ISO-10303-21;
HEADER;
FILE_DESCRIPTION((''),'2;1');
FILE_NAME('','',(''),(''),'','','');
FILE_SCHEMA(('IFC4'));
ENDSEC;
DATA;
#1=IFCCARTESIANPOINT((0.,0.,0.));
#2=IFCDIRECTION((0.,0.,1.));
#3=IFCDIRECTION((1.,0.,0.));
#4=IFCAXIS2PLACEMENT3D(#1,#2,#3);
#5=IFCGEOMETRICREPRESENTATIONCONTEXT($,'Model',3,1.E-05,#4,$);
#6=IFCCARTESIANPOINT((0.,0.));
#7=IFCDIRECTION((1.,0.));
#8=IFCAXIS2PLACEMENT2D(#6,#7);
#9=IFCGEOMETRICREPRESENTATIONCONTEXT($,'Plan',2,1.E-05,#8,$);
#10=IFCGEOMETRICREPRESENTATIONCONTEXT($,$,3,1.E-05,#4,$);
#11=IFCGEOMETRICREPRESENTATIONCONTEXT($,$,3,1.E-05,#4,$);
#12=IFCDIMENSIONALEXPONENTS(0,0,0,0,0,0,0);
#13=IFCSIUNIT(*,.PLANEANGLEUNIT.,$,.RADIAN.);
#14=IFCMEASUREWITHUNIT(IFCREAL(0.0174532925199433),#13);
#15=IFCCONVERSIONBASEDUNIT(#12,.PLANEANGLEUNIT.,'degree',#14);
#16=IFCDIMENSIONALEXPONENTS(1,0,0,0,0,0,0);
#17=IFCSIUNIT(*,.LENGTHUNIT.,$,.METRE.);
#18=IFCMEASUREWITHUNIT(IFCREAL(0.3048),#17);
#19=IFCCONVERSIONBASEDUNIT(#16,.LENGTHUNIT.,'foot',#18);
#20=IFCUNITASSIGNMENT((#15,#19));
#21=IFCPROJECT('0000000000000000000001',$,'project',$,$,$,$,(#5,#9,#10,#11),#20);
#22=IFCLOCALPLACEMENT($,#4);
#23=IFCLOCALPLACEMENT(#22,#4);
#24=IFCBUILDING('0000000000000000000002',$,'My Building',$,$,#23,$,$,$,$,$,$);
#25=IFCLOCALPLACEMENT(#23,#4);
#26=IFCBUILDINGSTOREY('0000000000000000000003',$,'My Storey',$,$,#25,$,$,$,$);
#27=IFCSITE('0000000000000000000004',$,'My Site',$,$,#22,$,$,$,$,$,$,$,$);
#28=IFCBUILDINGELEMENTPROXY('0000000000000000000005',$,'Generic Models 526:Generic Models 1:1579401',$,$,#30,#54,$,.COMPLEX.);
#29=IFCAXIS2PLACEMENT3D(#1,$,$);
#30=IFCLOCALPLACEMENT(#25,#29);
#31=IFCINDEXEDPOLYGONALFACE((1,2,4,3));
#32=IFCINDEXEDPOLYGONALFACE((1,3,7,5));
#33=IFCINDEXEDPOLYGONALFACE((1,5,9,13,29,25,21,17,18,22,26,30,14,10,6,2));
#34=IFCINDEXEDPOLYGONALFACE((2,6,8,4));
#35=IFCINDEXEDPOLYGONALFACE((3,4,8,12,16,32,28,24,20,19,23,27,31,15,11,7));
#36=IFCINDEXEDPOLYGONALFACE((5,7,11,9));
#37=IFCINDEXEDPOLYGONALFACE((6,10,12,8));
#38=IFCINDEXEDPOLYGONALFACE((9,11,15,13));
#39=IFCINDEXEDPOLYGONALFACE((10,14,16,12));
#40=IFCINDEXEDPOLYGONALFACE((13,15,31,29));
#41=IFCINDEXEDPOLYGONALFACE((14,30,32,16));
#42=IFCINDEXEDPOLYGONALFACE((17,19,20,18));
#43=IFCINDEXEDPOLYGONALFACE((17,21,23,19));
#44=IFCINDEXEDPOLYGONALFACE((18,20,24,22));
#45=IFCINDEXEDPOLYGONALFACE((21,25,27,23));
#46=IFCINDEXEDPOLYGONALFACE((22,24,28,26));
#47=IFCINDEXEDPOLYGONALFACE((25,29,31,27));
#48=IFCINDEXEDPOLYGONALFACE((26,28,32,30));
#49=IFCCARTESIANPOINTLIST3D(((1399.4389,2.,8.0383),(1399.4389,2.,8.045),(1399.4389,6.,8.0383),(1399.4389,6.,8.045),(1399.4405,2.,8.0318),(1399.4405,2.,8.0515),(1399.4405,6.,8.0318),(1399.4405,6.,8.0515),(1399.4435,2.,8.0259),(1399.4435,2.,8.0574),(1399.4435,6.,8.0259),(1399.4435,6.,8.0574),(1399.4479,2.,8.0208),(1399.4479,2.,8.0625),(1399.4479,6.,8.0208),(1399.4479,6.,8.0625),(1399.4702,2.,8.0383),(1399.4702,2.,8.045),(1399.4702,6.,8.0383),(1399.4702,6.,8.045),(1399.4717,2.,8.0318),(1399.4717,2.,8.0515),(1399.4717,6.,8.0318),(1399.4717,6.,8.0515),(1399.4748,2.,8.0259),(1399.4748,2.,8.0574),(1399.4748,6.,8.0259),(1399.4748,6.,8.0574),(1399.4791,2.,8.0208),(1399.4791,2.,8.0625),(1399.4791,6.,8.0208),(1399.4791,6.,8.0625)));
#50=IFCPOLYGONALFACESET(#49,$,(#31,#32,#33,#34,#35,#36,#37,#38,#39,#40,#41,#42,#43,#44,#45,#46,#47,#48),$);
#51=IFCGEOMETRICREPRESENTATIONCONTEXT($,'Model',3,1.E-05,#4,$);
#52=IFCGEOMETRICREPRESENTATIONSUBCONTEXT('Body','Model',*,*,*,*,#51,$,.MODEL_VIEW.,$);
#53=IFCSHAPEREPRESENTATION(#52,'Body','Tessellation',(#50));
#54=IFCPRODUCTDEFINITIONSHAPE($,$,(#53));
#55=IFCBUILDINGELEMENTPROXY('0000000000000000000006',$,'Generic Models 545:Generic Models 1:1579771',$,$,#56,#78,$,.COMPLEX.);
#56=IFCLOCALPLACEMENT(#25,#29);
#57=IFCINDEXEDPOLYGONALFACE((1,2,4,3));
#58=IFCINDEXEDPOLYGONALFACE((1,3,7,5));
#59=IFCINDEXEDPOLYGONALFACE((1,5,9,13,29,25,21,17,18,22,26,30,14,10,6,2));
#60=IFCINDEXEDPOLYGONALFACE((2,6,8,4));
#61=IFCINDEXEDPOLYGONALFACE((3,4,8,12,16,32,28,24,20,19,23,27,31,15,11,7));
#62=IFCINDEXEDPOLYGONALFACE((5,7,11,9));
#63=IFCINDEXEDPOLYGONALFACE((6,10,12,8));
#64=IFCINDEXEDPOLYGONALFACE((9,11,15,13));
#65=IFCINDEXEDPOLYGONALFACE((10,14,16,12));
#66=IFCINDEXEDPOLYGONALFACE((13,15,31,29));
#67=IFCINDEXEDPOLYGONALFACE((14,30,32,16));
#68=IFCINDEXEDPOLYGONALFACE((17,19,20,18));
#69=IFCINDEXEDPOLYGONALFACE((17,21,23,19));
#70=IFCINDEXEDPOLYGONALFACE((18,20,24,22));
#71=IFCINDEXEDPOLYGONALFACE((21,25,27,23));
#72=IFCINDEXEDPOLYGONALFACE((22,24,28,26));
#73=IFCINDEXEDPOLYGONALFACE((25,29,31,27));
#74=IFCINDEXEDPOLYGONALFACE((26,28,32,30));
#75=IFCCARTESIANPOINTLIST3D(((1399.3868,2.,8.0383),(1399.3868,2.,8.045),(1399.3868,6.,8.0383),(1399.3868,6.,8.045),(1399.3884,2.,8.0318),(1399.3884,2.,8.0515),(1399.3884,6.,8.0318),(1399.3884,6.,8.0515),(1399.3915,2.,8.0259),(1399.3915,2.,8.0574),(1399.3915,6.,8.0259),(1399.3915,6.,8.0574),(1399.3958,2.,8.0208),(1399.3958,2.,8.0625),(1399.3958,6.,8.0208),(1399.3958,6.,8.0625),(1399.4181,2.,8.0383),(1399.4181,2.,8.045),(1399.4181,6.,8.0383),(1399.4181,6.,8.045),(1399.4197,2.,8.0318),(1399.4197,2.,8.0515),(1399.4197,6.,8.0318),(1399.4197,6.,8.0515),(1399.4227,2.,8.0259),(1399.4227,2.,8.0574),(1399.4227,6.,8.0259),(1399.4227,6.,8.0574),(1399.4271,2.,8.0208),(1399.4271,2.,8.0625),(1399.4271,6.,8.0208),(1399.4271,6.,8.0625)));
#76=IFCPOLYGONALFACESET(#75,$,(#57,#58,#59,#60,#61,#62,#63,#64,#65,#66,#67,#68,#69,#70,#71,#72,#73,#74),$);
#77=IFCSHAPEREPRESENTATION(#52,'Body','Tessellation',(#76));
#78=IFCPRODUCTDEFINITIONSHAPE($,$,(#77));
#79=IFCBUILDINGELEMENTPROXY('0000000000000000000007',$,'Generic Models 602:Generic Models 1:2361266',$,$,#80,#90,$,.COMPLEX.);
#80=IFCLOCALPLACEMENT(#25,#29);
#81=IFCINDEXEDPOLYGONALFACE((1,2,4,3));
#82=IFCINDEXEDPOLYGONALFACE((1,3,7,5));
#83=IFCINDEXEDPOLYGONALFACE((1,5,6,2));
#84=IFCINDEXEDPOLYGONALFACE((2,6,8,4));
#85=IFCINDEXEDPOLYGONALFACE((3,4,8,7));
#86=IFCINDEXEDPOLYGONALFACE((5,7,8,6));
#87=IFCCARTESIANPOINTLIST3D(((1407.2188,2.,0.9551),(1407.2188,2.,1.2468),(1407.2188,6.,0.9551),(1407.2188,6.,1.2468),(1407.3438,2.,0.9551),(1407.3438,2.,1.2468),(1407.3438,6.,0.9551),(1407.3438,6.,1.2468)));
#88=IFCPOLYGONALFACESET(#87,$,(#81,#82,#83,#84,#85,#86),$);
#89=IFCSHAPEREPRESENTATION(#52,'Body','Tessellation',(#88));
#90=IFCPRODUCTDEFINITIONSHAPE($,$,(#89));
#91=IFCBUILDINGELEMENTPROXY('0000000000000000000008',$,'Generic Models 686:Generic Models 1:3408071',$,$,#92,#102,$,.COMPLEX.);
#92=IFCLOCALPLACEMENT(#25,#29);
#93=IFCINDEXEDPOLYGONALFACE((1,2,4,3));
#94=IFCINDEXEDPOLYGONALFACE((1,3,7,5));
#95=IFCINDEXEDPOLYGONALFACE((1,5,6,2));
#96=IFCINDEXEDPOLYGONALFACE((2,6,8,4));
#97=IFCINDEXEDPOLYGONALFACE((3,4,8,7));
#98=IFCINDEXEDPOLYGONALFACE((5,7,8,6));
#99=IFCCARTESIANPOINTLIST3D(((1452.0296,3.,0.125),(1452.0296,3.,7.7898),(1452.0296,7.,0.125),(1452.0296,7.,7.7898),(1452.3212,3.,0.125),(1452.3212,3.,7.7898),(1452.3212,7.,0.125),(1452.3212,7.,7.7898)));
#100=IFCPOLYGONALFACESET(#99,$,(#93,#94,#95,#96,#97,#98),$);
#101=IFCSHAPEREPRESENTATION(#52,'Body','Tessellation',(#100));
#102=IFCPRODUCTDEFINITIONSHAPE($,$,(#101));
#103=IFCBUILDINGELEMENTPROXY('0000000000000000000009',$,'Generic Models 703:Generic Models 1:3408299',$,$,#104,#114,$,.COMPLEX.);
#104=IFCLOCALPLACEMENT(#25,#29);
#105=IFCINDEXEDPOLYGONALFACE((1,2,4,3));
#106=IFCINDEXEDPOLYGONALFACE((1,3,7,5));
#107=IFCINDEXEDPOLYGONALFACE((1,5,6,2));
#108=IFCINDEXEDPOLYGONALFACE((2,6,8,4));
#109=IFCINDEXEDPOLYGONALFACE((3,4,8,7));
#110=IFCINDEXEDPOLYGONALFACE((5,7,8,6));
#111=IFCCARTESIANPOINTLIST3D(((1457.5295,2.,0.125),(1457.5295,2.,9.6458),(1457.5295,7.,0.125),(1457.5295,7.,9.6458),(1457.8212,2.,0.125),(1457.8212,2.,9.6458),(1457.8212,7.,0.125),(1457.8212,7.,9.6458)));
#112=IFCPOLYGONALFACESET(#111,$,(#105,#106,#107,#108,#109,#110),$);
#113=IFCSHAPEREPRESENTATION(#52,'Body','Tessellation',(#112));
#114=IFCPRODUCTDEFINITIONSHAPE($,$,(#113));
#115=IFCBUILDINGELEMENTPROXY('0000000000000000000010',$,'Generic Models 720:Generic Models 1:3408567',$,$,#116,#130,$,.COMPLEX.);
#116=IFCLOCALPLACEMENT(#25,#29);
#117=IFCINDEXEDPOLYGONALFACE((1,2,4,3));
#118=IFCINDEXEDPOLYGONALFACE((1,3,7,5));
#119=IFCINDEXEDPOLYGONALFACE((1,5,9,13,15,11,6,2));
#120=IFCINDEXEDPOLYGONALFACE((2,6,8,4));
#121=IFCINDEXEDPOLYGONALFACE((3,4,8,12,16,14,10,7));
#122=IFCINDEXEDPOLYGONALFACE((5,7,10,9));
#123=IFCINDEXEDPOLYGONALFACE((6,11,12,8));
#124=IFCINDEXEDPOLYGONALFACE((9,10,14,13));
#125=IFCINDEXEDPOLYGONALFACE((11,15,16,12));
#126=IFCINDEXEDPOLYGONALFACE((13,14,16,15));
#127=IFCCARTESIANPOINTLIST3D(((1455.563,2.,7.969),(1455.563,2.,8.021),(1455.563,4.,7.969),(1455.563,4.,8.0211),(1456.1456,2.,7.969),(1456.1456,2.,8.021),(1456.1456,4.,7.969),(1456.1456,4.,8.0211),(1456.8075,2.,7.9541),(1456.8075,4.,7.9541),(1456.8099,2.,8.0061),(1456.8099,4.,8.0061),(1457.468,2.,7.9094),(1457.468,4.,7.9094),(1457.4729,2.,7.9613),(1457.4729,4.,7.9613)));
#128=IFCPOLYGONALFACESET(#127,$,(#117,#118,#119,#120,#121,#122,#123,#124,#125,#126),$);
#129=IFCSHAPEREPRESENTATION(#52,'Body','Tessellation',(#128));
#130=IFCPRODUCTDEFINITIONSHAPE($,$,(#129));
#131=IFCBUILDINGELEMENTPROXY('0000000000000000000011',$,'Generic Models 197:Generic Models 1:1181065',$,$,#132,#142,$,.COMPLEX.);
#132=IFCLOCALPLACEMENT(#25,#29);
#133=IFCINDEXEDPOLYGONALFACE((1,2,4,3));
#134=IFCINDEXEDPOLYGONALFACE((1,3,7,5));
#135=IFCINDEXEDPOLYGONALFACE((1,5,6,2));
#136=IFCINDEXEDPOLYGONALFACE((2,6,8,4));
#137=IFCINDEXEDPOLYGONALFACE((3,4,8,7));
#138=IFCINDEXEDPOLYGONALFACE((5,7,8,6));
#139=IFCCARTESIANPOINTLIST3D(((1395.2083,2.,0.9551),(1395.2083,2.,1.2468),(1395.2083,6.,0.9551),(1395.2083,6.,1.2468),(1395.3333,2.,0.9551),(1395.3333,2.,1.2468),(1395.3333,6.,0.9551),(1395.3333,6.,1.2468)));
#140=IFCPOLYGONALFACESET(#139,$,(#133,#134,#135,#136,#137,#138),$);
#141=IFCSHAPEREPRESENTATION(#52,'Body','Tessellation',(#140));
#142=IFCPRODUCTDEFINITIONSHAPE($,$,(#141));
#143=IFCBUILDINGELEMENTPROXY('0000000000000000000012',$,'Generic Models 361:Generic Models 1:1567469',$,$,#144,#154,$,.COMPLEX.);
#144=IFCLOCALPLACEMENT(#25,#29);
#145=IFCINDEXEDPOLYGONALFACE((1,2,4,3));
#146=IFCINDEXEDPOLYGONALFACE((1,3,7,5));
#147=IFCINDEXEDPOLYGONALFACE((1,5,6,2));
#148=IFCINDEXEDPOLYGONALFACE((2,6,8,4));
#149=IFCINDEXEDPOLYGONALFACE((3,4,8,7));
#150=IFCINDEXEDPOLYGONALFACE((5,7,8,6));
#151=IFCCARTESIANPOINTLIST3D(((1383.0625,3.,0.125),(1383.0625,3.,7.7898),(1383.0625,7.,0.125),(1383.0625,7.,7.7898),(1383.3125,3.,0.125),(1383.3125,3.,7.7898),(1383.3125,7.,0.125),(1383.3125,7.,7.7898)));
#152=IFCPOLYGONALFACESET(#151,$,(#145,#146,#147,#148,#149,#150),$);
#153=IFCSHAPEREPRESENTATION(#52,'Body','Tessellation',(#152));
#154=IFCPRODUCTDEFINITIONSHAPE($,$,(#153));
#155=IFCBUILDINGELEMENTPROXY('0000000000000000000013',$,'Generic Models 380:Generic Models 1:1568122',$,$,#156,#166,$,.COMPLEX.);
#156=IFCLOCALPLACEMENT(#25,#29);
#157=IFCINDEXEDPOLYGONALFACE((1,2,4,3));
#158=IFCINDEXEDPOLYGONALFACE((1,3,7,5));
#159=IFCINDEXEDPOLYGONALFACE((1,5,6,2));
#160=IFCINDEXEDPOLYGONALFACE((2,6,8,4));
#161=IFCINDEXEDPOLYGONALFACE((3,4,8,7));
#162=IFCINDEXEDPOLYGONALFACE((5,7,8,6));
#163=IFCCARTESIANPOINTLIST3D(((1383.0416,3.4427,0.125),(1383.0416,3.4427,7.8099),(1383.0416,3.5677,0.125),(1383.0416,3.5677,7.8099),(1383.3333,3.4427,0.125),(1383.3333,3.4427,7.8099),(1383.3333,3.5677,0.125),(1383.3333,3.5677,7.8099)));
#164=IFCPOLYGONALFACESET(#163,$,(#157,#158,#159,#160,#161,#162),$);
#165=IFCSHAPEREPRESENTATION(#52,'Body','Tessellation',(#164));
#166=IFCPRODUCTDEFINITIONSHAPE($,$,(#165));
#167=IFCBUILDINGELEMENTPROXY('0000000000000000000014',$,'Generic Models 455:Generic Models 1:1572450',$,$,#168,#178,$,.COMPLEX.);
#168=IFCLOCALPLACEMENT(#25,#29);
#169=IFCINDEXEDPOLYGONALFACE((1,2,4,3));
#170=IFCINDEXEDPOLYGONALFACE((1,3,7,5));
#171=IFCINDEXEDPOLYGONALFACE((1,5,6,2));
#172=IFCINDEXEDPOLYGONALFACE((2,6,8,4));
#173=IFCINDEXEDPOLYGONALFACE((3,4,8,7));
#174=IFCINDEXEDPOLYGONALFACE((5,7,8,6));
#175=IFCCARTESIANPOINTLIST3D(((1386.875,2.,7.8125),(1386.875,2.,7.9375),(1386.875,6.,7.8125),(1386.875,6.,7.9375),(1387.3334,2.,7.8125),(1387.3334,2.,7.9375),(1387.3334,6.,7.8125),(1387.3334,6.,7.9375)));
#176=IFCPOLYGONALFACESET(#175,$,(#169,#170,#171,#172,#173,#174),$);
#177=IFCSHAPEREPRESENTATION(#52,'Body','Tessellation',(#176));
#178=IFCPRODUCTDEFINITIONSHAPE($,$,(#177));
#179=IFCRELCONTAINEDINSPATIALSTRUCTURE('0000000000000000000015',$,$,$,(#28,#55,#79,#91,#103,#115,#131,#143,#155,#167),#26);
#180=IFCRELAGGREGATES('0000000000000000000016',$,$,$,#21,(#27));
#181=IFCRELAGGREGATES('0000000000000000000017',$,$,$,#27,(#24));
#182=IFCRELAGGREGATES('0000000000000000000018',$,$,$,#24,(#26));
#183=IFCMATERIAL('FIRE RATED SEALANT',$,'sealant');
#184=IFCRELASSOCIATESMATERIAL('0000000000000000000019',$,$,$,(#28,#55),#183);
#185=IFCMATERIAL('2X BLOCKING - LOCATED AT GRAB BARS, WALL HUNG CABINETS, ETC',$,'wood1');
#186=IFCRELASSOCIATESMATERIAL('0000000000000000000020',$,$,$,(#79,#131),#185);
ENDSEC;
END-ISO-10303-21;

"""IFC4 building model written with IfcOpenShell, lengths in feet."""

from ifc_helpers import new_model, entity, si_unit, converted_unit, frame, origin_with_axes, origin_2d_with_axis, place, context, subcontext, project, spatial, polyline, outline, extrude, material, element, save


model = new_model("IFC4")

# Units and contexts
model_context_1 = context("Model", 3, precision=1e-05, world=origin_with_axes())
plan_context = context("Plan", 2, precision=1e-05, world=origin_2d_with_axis())
model_context_2 = context("Model", 3, precision=1e-05, world=origin_with_axes())
context_of_model_1 = context(None, 3, precision=1e-05, world=origin_with_axes())
context_of_model_2 = context(None, 3, precision=1e-05, world=origin_with_axes())
body_context = subcontext(model_context_2, "Body", "Model", "MODEL_VIEW")
ifc_project = project(units=[converted_unit("PLANEANGLEUNIT", "degree", entity("IfcReal", 0.0174532925199433), si_unit("PLANEANGLEUNIT", "RADIAN"), dimensions=[0, 0, 0, 0, 0, 0, 0]), converted_unit("LENGTHUNIT", "foot", entity("IfcReal", 0.3048), si_unit("LENGTHUNIT", "METRE"), dimensions=[1, 0, 0, 0, 0, 0, 0])], contexts=[model_context_1, plan_context, context_of_model_1, context_of_model_2])

# Site, building, storey
site_placement = place(None, origin_with_axes())
site = spatial("IfcSite", under=ifc_project, at=site_placement, Name="My Site")
building_placement = place(site_placement, origin_with_axes())
building = spatial("IfcBuilding", under=site, at=building_placement, Name="My Building")
storey_placement = place(building_placement, origin_with_axes())
storey = spatial("IfcBuildingStorey", under=building, at=storey_placement, Name="My Storey")

# Building element proxies
ifc_material_1 = material(Name="FIRE RATED SEALANT", Category="sealant")
proxy_1_placement = place(storey_placement, frame((1399.4389, 6.0, 8.0208), z_axis=(0.0, -1.0, 0.0), x_axis=(0.0, 0.0, 1.0)))
element("IfcBuildingElementProxy", 1, at=proxy_1_placement, inside=storey, material=ifc_material_1, Name="Generic Models 526:Generic Models 1:1579401", PredefinedType="COMPLEX", context=body_context, shape_type="SweptSolid", body=[
    extrude(outline(polyline([(0.0294, 0.0), (0.0074, 0.0221), (0.0007, 0.0216), (-0.0057, 0.0196), (-0.0114, 0.0161), (-0.0161, 0.0114), (-0.0196, 0.0057), (-0.0216, -0.0007), (-0.0221, -0.0073), (0.0, -0.0294), (0.0005, -0.0228), (0.0025, -0.0164), (0.006, -0.0107), (0.0107, -0.006), (0.0164, -0.0025), (0.0228, -0.0005), (0.0294, 0.0)])), frame((0.0208, -0.0194, 0.0), z_axis=(0.0, 0.0, -1.0), x_axis=(-0.707667, -0.706546, 0.0)), (0.0, 0.0, -1.0), 4.0),
])
proxy_2_placement = place(storey_placement, frame((1399.3868, 6.0, 8.0208), z_axis=(0.0, -1.0, 0.0), x_axis=(0.0, 0.0, 1.0)))
element("IfcBuildingElementProxy", 2, at=proxy_2_placement, inside=storey, material=ifc_material_1, Name="Generic Models 545:Generic Models 1:1579771", PredefinedType="COMPLEX", context=body_context, shape_type="SweptSolid", body=[
    extrude(outline(polyline([(0.0166, 0.0), (0.0115, 0.0043), (0.0076, 0.0097), (0.005, 0.0159), (0.0039, 0.0224), (0.0045, 0.0291), (-0.0207, 0.0106), (-0.0213, 0.004), (-0.0202, -0.0026), (-0.0176, -0.0088), (-0.0137, -0.0142), (-0.0086, -0.0185), (-0.0026, -0.0215), (0.0039, -0.023), (0.0291, -0.0045), (0.0226, -0.003), (0.0166, 0.0)])), frame((0.0208, -0.0194, 0.0), z_axis=(0.0, 0.0, -1.0), x_axis=(0.591192, -0.806531, 0.0)), (0.0, 0.0, -1.0), 4.0),
])
ifc_material_2 = material(Name="2X BLOCKING - LOCATED AT GRAB BARS, WALL HUNG CABINETS, ETC", Category="wood1")
proxy_3_placement = place(storey_placement, frame((1407.2188, 6.0, 0.9551), z_axis=(0.0, -1.0, 0.0), x_axis=(0.0, 0.0, 1.0)))
element("IfcBuildingElementProxy", 3, at=proxy_3_placement, inside=storey, material=ifc_material_2, Name="Generic Models 602:Generic Models 1:2361266", PredefinedType="COMPLEX", context=body_context, shape_type="SweptSolid", body=[
    extrude(outline(polyline([(-0.1458, -0.0625), (0.1458, -0.0625), (0.1458, 0.0625), (-0.1458, 0.0625), (-0.1458, -0.0625)])), frame((0.1458, -0.0625, 0.0), z_axis=(0.0, 0.0, -1.0), x_axis=(1.0, 0.0, 0.0)), (0.0, 0.0, -1.0), 4.0),
])
proxy_4_placement = place(storey_placement, frame((1452.0296, 7.0, 0.125), z_axis=(0.0, -1.0, 0.0), x_axis=(0.0, 0.0, 1.0)))
element("IfcBuildingElementProxy", 4, at=proxy_4_placement, inside=storey, Name="Generic Models 686:Generic Models 1:3408071", PredefinedType="COMPLEX", context=body_context, shape_type="SweptSolid", body=[
    extrude(outline(polyline([(-3.8324, -0.1458), (3.8324, -0.1458), (3.8324, 0.1458), (-3.8324, 0.1458), (-3.8324, -0.1458)])), frame((3.8324, -0.1458, 0.0), z_axis=(0.0, 0.0, -1.0), x_axis=(1.0, 0.0, 0.0)), (0.0, 0.0, -1.0), 4.0),
])
proxy_5_placement = place(storey_placement, frame((1457.5295, 6.0, 0.125), z_axis=(0.0, -1.0, 0.0), x_axis=(0.0, 0.0, 1.0)))
element("IfcBuildingElementProxy", 5, at=proxy_5_placement, inside=storey, Name="Generic Models 703:Generic Models 1:3408299", PredefinedType="COMPLEX", context=body_context, shape_type="SweptSolid", body=[
    extrude(outline(polyline([(-4.7604, -0.1458), (4.7604, -0.1458), (4.7604, 0.1458), (-4.7604, 0.1458), (-4.7604, -0.1458)])), frame((4.7604, -0.1458, -1.0), z_axis=(0.0, 0.0, -1.0), x_axis=(1.0, 0.0, 0.0)), (0.0, 0.0, -1.0), 5.0),
])
proxy_6_placement = place(storey_placement, frame((1455.563, 6.0, 7.9094), z_axis=(0.0, -1.0, 0.0), x_axis=(0.0, 0.0, 1.0)))
element("IfcBuildingElementProxy", 6, at=proxy_6_placement, inside=storey, Name="Generic Models 720:Generic Models 1:3408567", PredefinedType="COMPLEX", context=body_context, shape_type="SweptSolid", body=[
    extrude(outline(polyline([(-0.0074, -0.9339), (0.0447, -0.9339), (0.0447, -0.3513), (0.0297, 0.313), (-0.0151, 0.9759), (-0.0669, 0.9711), (-0.0223, 0.3105), (-0.0074, -0.3513), (-0.0074, -0.9339)])), frame((0.0669, -0.9339, 2.0), z_axis=(0.000003, 0.0, -1.0), x_axis=(1.0, 0.0, 0.0)), (0.0, 0.0, -1.0), 2.0),
])
proxy_7_placement = place(storey_placement, frame((1395.2083, 6.0, 0.9551), z_axis=(0.0, -1.0, 0.0), x_axis=(0.0, 0.0, 1.0)))
element("IfcBuildingElementProxy", 7, at=proxy_7_placement, inside=storey, material=ifc_material_2, Name="Generic Models 197:Generic Models 1:1181065", PredefinedType="COMPLEX", context=body_context, shape_type="SweptSolid", body=[
    extrude(outline(polyline([(-0.0625, -0.1458), (0.0625, -0.1458), (0.0625, 0.1458), (-0.0625, 0.1458), (-0.0625, -0.1458)])), frame((0.1458, -0.0625, 0.0), z_axis=(0.0, 0.0, -1.0), x_axis=(0.0, -1.0, 0.0)), (0.0, 0.0, -1.0), 4.0),
])
proxy_8_placement = place(storey_placement, frame((1383.0625, 7.0, 0.125), z_axis=(0.0, -1.0, 0.0), x_axis=(0.0, 0.0, 1.0)))
element("IfcBuildingElementProxy", 8, at=proxy_8_placement, inside=storey, Name="Generic Models 361:Generic Models 1:1567469", PredefinedType="COMPLEX", context=body_context, shape_type="SweptSolid", body=[
    extrude(outline(polyline([(-0.125, -3.8324), (0.125, -3.8324), (0.125, 3.8324), (-0.125, 3.8324), (-0.125, -3.8324)])), frame((3.8324, -0.125, 0.0), z_axis=(0.0, 0.0, -1.0), x_axis=(0.0, 1.0, 0.0)), (0.0, 0.0, -1.0), 4.0),
])
proxy_9_placement = place(storey_placement, frame((1383.0416, 7.4427, 0.125), z_axis=(0.0, -1.0, 0.0), x_axis=(1.0, 0.0, 0.0)))
element("IfcBuildingElementProxy", 9, at=proxy_9_placement, inside=storey, Name="Generic Models 380:Generic Models 1:1568122", PredefinedType="COMPLEX", context=body_context, shape_type="SweptSolid", body=[
    extrude(outline(polyline([(-0.1458, -3.8424), (0.1458, -3.8424), (0.1458, 3.8424), (-0.1458, 3.8424), (-0.1458, -3.8424)])), frame((0.1458, 3.8424, 3.875), z_axis=(0.0, 0.0, -1.0), x_axis=(-1.0, 0.0, 0.0)), (0.0, 0.000002, -1.0), 0.125),
])
proxy_10_placement = place(storey_placement, frame((1386.875, 6.0, 7.8125), z_axis=(0.0, -1.0, 0.0), x_axis=(0.0, 0.0, 1.0)))
element("IfcBuildingElementProxy", 10, at=proxy_10_placement, inside=storey, Name="Generic Models 455:Generic Models 1:1572450", PredefinedType="COMPLEX", context=body_context, shape_type="SweptSolid", body=[
    extrude(outline(polyline([(-0.2292, -0.0625), (0.2292, -0.0625), (0.2292, 0.0625), (-0.2292, 0.0625), (-0.2292, -0.0625)])), frame((0.0625, -0.2292, 0.0), z_axis=(0.0, 0.0, -1.0), x_axis=(0.0, 1.0, 0.0)), (0.0, 0.0, -1.0), 4.0),
])

save(model, "model.ifc")
